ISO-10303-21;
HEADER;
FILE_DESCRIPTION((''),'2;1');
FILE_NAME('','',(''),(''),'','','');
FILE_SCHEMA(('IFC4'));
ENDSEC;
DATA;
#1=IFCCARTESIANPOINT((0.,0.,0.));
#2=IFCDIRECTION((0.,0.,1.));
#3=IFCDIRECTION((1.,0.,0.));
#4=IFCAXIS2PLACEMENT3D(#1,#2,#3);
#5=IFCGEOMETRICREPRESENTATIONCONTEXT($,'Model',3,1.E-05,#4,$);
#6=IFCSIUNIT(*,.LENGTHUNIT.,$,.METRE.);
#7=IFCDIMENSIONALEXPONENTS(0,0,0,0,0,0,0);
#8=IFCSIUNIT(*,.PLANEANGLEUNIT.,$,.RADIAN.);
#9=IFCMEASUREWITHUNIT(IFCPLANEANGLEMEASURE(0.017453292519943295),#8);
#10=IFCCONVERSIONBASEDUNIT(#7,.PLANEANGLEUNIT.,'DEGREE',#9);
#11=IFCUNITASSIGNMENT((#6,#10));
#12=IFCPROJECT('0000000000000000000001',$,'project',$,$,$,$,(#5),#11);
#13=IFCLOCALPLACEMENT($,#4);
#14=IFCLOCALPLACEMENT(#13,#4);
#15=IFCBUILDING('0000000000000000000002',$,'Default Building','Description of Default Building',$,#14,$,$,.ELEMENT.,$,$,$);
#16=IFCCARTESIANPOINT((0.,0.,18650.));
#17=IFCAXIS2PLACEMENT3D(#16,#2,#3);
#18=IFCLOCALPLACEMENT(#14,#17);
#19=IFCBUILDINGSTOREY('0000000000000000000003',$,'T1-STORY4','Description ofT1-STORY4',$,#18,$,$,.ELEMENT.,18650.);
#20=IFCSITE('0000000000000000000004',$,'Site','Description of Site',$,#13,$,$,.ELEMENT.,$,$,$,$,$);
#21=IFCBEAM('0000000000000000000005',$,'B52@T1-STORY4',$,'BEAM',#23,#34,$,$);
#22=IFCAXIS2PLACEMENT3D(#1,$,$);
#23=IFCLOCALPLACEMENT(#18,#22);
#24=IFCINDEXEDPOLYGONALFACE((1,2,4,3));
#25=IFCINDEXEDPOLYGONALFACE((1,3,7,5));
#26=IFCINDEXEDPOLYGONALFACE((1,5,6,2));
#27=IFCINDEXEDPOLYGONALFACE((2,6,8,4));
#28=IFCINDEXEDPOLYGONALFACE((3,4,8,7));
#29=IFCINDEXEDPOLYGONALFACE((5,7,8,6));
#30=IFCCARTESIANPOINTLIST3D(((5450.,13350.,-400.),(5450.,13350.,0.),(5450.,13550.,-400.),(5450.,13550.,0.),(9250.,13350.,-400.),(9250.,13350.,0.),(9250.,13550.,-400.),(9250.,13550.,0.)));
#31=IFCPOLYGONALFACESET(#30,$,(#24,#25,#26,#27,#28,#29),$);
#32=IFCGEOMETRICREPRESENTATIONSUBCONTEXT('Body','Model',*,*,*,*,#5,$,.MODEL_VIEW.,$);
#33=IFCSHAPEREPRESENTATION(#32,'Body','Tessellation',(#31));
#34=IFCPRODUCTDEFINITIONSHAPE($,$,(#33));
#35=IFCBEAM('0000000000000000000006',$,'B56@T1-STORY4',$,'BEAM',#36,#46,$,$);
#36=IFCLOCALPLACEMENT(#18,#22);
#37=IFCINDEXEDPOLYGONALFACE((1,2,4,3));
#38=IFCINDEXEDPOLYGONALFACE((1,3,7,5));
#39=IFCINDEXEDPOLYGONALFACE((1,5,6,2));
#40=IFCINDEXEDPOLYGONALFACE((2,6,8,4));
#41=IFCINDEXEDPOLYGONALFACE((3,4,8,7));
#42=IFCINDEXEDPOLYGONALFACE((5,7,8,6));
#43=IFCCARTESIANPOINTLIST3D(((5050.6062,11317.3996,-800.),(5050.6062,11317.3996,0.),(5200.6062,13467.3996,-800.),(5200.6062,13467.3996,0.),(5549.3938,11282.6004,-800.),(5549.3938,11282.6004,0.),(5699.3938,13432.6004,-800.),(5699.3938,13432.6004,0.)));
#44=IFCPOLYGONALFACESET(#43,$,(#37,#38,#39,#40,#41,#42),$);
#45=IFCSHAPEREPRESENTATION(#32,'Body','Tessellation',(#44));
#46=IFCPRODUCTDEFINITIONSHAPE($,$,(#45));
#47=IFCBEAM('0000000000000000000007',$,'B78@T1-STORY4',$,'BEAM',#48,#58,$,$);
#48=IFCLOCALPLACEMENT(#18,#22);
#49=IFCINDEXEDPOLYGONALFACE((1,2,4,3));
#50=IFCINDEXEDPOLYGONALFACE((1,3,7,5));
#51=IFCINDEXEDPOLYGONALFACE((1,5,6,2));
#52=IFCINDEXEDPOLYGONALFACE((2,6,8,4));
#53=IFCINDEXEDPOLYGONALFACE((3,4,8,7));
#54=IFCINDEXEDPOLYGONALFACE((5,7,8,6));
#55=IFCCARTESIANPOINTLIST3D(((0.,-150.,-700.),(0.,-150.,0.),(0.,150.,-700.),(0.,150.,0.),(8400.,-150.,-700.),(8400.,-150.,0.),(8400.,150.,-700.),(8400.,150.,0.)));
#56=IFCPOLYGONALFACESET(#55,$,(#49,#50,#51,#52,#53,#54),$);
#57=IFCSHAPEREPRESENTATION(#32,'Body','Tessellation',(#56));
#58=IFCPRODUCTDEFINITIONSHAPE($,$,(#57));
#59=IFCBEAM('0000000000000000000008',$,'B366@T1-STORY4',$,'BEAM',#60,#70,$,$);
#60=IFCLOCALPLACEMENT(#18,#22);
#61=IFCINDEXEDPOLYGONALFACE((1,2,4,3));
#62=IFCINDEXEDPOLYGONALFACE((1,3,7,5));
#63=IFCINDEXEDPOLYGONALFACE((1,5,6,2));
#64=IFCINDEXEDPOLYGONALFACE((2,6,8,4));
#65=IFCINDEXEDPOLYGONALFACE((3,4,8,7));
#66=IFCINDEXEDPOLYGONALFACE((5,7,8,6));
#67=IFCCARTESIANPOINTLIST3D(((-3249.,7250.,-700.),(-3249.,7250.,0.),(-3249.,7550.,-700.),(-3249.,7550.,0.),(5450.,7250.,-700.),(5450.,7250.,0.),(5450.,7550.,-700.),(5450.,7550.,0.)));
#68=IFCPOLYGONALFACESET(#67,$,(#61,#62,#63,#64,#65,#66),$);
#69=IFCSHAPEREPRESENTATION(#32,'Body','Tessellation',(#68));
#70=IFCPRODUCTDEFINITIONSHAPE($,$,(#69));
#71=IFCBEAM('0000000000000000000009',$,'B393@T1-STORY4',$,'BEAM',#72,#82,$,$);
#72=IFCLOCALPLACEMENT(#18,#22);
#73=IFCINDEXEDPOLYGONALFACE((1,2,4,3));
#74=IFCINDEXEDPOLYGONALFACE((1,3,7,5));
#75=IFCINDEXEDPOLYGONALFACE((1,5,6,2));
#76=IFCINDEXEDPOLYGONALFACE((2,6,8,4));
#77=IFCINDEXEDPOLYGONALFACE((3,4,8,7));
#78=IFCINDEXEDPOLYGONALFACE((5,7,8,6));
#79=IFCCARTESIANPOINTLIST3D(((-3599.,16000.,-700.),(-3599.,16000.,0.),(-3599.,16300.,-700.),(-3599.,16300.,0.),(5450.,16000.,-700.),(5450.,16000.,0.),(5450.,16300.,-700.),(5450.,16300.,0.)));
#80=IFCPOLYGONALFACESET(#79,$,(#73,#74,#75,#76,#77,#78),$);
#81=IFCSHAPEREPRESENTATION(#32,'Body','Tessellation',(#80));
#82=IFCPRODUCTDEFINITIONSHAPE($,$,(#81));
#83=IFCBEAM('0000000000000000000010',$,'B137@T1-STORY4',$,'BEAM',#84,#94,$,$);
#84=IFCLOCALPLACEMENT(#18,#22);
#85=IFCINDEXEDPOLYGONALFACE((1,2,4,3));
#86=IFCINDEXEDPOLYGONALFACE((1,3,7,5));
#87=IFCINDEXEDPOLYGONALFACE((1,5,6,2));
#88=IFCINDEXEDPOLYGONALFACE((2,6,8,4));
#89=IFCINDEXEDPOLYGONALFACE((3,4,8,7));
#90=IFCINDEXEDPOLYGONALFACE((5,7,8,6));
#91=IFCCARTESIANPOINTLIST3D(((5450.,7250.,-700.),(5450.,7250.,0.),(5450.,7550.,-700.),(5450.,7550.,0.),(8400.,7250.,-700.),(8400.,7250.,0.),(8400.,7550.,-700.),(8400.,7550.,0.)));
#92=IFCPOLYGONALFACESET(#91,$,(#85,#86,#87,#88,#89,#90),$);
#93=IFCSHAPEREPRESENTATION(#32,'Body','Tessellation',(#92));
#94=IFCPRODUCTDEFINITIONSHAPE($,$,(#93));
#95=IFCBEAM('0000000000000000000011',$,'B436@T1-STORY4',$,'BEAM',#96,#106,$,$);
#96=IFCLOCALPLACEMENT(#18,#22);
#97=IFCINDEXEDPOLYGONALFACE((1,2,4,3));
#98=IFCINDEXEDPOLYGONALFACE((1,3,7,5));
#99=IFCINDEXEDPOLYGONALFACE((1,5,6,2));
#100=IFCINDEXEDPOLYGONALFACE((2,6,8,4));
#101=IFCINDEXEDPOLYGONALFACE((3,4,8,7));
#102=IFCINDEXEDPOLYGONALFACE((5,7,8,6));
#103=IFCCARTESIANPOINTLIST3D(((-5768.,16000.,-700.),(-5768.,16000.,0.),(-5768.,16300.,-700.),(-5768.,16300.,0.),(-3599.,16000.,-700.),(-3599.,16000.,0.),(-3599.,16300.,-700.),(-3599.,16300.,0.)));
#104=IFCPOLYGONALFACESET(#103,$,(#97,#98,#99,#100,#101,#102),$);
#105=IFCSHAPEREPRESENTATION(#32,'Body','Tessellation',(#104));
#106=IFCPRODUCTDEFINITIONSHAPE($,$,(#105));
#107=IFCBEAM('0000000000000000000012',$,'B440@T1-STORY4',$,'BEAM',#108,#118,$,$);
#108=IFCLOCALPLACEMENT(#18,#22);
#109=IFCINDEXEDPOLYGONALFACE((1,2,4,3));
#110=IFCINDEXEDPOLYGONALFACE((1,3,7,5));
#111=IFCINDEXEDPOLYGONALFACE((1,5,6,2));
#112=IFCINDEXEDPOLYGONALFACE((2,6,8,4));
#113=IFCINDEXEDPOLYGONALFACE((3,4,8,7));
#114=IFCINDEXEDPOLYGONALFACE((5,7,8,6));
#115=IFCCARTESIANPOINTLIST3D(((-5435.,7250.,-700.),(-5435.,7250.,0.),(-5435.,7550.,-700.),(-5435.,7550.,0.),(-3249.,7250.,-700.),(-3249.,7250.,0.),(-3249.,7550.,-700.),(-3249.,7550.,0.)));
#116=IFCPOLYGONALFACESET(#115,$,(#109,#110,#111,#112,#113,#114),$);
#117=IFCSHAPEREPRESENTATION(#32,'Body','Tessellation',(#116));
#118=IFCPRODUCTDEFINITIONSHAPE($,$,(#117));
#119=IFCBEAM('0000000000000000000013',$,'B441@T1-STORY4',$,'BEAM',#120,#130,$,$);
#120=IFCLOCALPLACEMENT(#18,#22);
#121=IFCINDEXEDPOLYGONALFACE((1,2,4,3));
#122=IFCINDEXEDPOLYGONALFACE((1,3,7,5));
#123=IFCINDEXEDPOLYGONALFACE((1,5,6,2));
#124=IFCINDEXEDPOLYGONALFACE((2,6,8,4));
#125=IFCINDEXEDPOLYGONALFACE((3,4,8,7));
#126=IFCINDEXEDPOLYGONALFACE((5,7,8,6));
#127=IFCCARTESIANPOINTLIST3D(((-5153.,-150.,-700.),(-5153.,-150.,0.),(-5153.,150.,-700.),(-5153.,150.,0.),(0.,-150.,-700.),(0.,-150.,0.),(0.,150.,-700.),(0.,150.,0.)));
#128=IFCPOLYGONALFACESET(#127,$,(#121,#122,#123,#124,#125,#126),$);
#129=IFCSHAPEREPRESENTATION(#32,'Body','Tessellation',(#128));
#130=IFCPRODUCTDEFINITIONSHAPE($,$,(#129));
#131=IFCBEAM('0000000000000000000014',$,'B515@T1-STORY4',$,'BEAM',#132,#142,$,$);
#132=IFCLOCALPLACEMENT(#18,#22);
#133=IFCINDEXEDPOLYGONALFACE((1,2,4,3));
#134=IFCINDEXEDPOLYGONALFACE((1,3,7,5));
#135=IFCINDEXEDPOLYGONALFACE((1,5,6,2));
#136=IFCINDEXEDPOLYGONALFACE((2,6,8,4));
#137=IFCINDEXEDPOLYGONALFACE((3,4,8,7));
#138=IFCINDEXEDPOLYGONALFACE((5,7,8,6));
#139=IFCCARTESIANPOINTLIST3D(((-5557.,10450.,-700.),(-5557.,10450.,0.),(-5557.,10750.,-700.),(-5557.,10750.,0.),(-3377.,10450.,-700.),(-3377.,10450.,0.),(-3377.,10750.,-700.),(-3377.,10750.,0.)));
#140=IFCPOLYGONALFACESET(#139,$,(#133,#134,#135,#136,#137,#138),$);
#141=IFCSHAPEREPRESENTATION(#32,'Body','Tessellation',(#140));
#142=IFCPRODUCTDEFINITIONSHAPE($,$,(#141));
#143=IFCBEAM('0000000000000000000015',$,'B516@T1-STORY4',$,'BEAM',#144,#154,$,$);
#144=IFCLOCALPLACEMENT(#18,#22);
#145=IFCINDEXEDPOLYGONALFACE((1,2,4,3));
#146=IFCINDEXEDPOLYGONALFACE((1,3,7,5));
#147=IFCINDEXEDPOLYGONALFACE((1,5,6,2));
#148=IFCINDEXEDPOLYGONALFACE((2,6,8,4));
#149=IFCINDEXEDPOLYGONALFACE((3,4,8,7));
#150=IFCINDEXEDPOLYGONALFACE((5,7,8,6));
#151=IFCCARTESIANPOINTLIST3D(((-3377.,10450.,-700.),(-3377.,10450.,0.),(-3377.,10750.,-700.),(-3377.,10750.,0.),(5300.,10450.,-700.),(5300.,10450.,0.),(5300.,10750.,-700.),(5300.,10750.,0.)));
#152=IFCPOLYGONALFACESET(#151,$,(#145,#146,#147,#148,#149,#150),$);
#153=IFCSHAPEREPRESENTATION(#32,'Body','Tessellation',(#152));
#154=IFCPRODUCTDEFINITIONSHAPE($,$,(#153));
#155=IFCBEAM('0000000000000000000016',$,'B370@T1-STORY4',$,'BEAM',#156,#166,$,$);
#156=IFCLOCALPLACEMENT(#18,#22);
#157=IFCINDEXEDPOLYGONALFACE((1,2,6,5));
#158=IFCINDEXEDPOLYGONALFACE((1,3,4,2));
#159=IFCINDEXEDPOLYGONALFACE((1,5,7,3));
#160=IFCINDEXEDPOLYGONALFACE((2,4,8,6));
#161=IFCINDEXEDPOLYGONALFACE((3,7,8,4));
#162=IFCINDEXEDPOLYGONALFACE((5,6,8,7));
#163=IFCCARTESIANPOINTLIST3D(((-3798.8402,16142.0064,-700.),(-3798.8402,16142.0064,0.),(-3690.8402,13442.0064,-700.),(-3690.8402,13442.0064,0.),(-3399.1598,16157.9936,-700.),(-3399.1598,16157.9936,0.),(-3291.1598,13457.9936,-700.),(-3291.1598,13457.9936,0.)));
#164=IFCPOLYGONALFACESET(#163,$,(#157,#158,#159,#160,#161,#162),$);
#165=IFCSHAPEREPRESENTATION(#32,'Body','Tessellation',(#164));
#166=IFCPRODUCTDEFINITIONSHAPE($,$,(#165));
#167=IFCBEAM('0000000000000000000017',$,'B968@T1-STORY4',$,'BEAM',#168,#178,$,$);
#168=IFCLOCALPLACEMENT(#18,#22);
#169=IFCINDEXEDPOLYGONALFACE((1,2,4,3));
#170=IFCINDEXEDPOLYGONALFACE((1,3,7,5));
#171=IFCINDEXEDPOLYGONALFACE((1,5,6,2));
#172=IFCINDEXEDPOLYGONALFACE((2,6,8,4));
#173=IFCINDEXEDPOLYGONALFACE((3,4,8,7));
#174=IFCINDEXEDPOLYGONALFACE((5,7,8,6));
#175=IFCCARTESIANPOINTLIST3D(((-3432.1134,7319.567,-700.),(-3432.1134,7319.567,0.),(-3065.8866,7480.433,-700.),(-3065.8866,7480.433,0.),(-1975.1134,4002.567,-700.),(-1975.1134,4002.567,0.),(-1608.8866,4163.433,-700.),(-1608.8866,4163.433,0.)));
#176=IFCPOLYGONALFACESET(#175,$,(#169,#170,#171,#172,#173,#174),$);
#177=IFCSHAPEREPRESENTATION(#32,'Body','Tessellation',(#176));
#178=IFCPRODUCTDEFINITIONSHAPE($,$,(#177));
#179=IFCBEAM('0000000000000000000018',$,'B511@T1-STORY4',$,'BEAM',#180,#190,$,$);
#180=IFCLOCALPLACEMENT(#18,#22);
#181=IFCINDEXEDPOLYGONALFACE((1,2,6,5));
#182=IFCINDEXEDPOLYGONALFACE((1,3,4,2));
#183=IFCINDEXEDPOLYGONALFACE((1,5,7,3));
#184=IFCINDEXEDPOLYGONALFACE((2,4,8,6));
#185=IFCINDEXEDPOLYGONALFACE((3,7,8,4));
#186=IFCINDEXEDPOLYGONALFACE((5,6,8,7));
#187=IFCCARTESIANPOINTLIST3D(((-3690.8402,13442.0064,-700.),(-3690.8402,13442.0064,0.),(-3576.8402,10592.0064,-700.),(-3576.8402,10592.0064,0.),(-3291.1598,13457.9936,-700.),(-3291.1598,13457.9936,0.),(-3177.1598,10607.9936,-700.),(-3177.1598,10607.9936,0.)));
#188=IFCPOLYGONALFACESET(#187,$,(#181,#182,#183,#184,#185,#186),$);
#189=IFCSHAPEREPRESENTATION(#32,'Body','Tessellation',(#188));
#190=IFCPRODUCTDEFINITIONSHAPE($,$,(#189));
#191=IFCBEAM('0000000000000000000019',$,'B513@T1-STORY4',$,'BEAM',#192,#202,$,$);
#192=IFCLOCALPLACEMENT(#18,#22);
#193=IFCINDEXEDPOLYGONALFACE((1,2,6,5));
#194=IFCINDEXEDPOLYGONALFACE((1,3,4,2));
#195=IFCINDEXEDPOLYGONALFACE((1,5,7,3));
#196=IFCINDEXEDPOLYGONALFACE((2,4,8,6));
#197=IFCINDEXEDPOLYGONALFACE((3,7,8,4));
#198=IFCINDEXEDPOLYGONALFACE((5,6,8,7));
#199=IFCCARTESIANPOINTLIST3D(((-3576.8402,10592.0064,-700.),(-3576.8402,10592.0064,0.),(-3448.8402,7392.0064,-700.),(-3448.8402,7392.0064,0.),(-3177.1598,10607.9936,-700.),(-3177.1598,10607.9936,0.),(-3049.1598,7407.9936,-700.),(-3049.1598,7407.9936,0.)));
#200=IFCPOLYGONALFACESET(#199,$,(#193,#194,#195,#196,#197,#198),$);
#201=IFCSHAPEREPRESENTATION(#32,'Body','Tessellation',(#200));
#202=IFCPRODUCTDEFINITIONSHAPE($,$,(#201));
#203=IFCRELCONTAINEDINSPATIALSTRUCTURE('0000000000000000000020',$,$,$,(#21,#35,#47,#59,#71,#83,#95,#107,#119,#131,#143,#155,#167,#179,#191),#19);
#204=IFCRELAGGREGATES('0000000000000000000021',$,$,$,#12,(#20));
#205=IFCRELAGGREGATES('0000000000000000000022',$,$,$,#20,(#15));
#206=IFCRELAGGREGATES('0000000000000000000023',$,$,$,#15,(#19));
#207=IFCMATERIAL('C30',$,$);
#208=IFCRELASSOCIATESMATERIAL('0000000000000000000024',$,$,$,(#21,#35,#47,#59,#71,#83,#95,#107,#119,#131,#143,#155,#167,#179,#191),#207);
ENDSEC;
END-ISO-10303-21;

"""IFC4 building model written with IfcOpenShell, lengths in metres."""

from ifc_helpers import new_model, entity, si_unit, converted_unit, frame, origin_with_axes, place, context, subcontext, project, spatial, rectangle, extrude, material, element, save


model = new_model("IFC4")

# Units and contexts
model_context = context("Model", 3, precision=1e-05, world=origin_with_axes())
body_context = subcontext(model_context, "Body", "Model", "MODEL_VIEW")
ifc_project = project(units=[si_unit("LENGTHUNIT", "METRE"), converted_unit("PLANEANGLEUNIT", "DEGREE", entity("IfcPlaneAngleMeasure", 0.017453292519943295), si_unit("PLANEANGLEUNIT", "RADIAN"), dimensions=[0, 0, 0, 0, 0, 0, 0])], contexts=[model_context])

# Site, building, storey
site_placement = place(None, origin_with_axes())
site = spatial("IfcSite", under=ifc_project, at=site_placement, Name="Site", Description="Description of Site", CompositionType="ELEMENT")
building_placement = place(site_placement, origin_with_axes())
building = spatial("IfcBuilding", under=site, at=building_placement, Name="Default Building", Description="Description of Default Building", CompositionType="ELEMENT")
storey_placement = place(building_placement, frame((0.0, 0.0, 18650.0), z_axis=(0.0, 0.0, 1.0), x_axis=(1.0, 0.0, 0.0)))
storey = spatial("IfcBuildingStorey", under=building, at=storey_placement, Name="T1-STORY4", Description="Description ofT1-STORY4", CompositionType="ELEMENT", Elevation=18650.0)

# Beams
ifc_material_1 = material(Name="C30")
beam_1_placement = place(storey_placement, frame((5450.0, 13450.0, -200.0), z_axis=(1.0, 0.0, 0.0), x_axis=(0.0, 1.0, 0.0)))
element("IfcBeam", 1, at=beam_1_placement, inside=storey, material=ifc_material_1, Name="B52@T1-STORY4", ObjectType="BEAM", context=body_context, shape_type="SweptSolid", body=[
    extrude(rectangle(XDim=200.0, YDim=400.0), origin_with_axes(), (0.0, 0.0, 1.0), 3800.0),
])
beam_2_placement = place(storey_placement, frame((5300.0, 11300.0, -400.0), z_axis=(0.069598, 0.997575, 0.0), x_axis=(-0.997575, 0.069598, 0.0)))
element("IfcBeam", 2, at=beam_2_placement, inside=storey, material=ifc_material_1, Name="B56@T1-STORY4", ObjectType="BEAM", context=body_context, shape_type="SweptSolid", body=[
    extrude(rectangle(XDim=500.0, YDim=800.0), origin_with_axes(), (0.0, 0.0, 1.0), 2155.2262),
])
beam_3_placement = place(storey_placement, frame((0.0, 0.0, -350.0), z_axis=(1.0, 0.0, 0.0), x_axis=(0.0, 1.0, 0.0)))
element("IfcBeam", 3, at=beam_3_placement, inside=storey, material=ifc_material_1, Name="B78@T1-STORY4", ObjectType="BEAM", context=body_context, shape_type="SweptSolid", body=[
    extrude(rectangle(XDim=300.0, YDim=700.0), origin_with_axes(), (0.0, 0.0, 1.0), 8400.0),
])
beam_4_placement = place(storey_placement, frame((-3249.0, 7400.0, -350.0), z_axis=(1.0, 0.0, 0.0), x_axis=(0.0, 1.0, 0.0)))
element("IfcBeam", 4, at=beam_4_placement, inside=storey, material=ifc_material_1, Name="B366@T1-STORY4", ObjectType="BEAM", context=body_context, shape_type="SweptSolid", body=[
    extrude(rectangle(XDim=300.0, YDim=700.0), origin_with_axes(), (0.0, 0.0, 1.0), 8699.0),
])
beam_5_placement = place(storey_placement, frame((-3599.0, 16150.0, -350.0), z_axis=(1.0, 0.0, 0.0), x_axis=(0.0, 1.0, 0.0)))
element("IfcBeam", 5, at=beam_5_placement, inside=storey, material=ifc_material_1, Name="B393@T1-STORY4", ObjectType="BEAM", context=body_context, shape_type="SweptSolid", body=[
    extrude(rectangle(XDim=300.0, YDim=700.0), origin_with_axes(), (0.0, 0.0, 1.0), 9049.0),
])
beam_6_placement = place(storey_placement, frame((5450.0, 7400.0, -350.0), z_axis=(1.0, 0.0, 0.0), x_axis=(0.0, 1.0, 0.0)))
element("IfcBeam", 6, at=beam_6_placement, inside=storey, material=ifc_material_1, Name="B137@T1-STORY4", ObjectType="BEAM", context=body_context, shape_type="SweptSolid", body=[
    extrude(rectangle(XDim=300.0, YDim=700.0), origin_with_axes(), (0.0, 0.0, 1.0), 2950.0),
])
beam_7_placement = place(storey_placement, frame((-5768.0, 16150.0, -350.0), z_axis=(1.0, 0.0, 0.0), x_axis=(0.0, 1.0, 0.0)))
element("IfcBeam", 7, at=beam_7_placement, inside=storey, material=ifc_material_1, Name="B436@T1-STORY4", ObjectType="BEAM", context=body_context, shape_type="SweptSolid", body=[
    extrude(rectangle(XDim=300.0, YDim=700.0), origin_with_axes(), (0.0, 0.0, 1.0), 2169.0),
])
beam_8_placement = place(storey_placement, frame((-5435.0, 7400.0, -350.0), z_axis=(1.0, 0.0, 0.0), x_axis=(0.0, 1.0, 0.0)))
element("IfcBeam", 8, at=beam_8_placement, inside=storey, material=ifc_material_1, Name="B440@T1-STORY4", ObjectType="BEAM", context=body_context, shape_type="SweptSolid", body=[
    extrude(rectangle(XDim=300.0, YDim=700.0), origin_with_axes(), (0.0, 0.0, 1.0), 2186.0),
])
beam_9_placement = place(storey_placement, frame((-5153.0, 0.0, -350.0), z_axis=(1.0, 0.0, 0.0), x_axis=(0.0, 1.0, 0.0)))
element("IfcBeam", 9, at=beam_9_placement, inside=storey, material=ifc_material_1, Name="B441@T1-STORY4", ObjectType="BEAM", context=body_context, shape_type="SweptSolid", body=[
    extrude(rectangle(XDim=300.0, YDim=700.0), origin_with_axes(), (0.0, 0.0, 1.0), 5153.0),
])
beam_10_placement = place(storey_placement, frame((-5557.0, 10600.0, -350.0), z_axis=(1.0, 0.0, 0.0), x_axis=(0.0, 1.0, 0.0)))
element("IfcBeam", 10, at=beam_10_placement, inside=storey, material=ifc_material_1, Name="B515@T1-STORY4", ObjectType="BEAM", context=body_context, shape_type="SweptSolid", body=[
    extrude(rectangle(XDim=300.0, YDim=700.0), origin_with_axes(), (0.0, 0.0, 1.0), 2180.0),
])
beam_11_placement = place(storey_placement, frame((-3377.0, 10600.0, -350.0), z_axis=(1.0, 0.0, 0.0), x_axis=(0.0, 1.0, 0.0)))
element("IfcBeam", 11, at=beam_11_placement, inside=storey, material=ifc_material_1, Name="B516@T1-STORY4", ObjectType="BEAM", context=body_context, shape_type="SweptSolid", body=[
    extrude(rectangle(XDim=300.0, YDim=700.0), origin_with_axes(), (0.0, 0.0, 1.0), 8677.0),
])
beam_12_placement = place(storey_placement, frame((-3599.0, 16150.0, -350.0), z_axis=(0.039968, -0.999201, 0.0), x_axis=(0.999201, 0.039968, 0.0)))
element("IfcBeam", 12, at=beam_12_placement, inside=storey, material=ifc_material_1, Name="B370@T1-STORY4", ObjectType="BEAM", context=body_context, shape_type="SweptSolid", body=[
    extrude(rectangle(XDim=400.0, YDim=700.0), origin_with_axes(), (0.0, 0.0, 1.0), 2702.1591),
])
beam_13_placement = place(storey_placement, frame((-3249.0, 7400.0, -350.0), z_axis=(0.402165, -0.915567, 0.0), x_axis=(0.915567, 0.402165, 0.0)))
element("IfcBeam", 13, at=beam_13_placement, inside=storey, material=ifc_material_1, Name="B968@T1-STORY4", ObjectType="BEAM", context=body_context, shape_type="SweptSolid", body=[
    extrude(rectangle(XDim=400.0, YDim=700.0), origin_with_axes(), (0.0, 0.0, 1.0), 3622.8908),
])
beam_14_placement = place(storey_placement, frame((-3491.0, 13450.0, -350.0), z_axis=(0.039968, -0.999201, 0.0), x_axis=(0.999201, 0.039968, 0.0)))
element("IfcBeam", 14, at=beam_14_placement, inside=storey, material=ifc_material_1, Name="B511@T1-STORY4", ObjectType="BEAM", context=body_context, shape_type="SweptSolid", body=[
    extrude(rectangle(XDim=400.0, YDim=700.0), origin_with_axes(), (0.0, 0.0, 1.0), 2852.2791),
])
beam_15_placement = place(storey_placement, frame((-3377.0, 10600.0, -350.0), z_axis=(0.039968, -0.999201, 0.0), x_axis=(0.999201, 0.039968, 0.0)))
element("IfcBeam", 15, at=beam_15_placement, inside=storey, material=ifc_material_1, Name="B513@T1-STORY4", ObjectType="BEAM", context=body_context, shape_type="SweptSolid", body=[
    extrude(rectangle(XDim=400.0, YDim=700.0), origin_with_axes(), (0.0, 0.0, 1.0), 3202.559),
])

save(model, "model.ifc")
